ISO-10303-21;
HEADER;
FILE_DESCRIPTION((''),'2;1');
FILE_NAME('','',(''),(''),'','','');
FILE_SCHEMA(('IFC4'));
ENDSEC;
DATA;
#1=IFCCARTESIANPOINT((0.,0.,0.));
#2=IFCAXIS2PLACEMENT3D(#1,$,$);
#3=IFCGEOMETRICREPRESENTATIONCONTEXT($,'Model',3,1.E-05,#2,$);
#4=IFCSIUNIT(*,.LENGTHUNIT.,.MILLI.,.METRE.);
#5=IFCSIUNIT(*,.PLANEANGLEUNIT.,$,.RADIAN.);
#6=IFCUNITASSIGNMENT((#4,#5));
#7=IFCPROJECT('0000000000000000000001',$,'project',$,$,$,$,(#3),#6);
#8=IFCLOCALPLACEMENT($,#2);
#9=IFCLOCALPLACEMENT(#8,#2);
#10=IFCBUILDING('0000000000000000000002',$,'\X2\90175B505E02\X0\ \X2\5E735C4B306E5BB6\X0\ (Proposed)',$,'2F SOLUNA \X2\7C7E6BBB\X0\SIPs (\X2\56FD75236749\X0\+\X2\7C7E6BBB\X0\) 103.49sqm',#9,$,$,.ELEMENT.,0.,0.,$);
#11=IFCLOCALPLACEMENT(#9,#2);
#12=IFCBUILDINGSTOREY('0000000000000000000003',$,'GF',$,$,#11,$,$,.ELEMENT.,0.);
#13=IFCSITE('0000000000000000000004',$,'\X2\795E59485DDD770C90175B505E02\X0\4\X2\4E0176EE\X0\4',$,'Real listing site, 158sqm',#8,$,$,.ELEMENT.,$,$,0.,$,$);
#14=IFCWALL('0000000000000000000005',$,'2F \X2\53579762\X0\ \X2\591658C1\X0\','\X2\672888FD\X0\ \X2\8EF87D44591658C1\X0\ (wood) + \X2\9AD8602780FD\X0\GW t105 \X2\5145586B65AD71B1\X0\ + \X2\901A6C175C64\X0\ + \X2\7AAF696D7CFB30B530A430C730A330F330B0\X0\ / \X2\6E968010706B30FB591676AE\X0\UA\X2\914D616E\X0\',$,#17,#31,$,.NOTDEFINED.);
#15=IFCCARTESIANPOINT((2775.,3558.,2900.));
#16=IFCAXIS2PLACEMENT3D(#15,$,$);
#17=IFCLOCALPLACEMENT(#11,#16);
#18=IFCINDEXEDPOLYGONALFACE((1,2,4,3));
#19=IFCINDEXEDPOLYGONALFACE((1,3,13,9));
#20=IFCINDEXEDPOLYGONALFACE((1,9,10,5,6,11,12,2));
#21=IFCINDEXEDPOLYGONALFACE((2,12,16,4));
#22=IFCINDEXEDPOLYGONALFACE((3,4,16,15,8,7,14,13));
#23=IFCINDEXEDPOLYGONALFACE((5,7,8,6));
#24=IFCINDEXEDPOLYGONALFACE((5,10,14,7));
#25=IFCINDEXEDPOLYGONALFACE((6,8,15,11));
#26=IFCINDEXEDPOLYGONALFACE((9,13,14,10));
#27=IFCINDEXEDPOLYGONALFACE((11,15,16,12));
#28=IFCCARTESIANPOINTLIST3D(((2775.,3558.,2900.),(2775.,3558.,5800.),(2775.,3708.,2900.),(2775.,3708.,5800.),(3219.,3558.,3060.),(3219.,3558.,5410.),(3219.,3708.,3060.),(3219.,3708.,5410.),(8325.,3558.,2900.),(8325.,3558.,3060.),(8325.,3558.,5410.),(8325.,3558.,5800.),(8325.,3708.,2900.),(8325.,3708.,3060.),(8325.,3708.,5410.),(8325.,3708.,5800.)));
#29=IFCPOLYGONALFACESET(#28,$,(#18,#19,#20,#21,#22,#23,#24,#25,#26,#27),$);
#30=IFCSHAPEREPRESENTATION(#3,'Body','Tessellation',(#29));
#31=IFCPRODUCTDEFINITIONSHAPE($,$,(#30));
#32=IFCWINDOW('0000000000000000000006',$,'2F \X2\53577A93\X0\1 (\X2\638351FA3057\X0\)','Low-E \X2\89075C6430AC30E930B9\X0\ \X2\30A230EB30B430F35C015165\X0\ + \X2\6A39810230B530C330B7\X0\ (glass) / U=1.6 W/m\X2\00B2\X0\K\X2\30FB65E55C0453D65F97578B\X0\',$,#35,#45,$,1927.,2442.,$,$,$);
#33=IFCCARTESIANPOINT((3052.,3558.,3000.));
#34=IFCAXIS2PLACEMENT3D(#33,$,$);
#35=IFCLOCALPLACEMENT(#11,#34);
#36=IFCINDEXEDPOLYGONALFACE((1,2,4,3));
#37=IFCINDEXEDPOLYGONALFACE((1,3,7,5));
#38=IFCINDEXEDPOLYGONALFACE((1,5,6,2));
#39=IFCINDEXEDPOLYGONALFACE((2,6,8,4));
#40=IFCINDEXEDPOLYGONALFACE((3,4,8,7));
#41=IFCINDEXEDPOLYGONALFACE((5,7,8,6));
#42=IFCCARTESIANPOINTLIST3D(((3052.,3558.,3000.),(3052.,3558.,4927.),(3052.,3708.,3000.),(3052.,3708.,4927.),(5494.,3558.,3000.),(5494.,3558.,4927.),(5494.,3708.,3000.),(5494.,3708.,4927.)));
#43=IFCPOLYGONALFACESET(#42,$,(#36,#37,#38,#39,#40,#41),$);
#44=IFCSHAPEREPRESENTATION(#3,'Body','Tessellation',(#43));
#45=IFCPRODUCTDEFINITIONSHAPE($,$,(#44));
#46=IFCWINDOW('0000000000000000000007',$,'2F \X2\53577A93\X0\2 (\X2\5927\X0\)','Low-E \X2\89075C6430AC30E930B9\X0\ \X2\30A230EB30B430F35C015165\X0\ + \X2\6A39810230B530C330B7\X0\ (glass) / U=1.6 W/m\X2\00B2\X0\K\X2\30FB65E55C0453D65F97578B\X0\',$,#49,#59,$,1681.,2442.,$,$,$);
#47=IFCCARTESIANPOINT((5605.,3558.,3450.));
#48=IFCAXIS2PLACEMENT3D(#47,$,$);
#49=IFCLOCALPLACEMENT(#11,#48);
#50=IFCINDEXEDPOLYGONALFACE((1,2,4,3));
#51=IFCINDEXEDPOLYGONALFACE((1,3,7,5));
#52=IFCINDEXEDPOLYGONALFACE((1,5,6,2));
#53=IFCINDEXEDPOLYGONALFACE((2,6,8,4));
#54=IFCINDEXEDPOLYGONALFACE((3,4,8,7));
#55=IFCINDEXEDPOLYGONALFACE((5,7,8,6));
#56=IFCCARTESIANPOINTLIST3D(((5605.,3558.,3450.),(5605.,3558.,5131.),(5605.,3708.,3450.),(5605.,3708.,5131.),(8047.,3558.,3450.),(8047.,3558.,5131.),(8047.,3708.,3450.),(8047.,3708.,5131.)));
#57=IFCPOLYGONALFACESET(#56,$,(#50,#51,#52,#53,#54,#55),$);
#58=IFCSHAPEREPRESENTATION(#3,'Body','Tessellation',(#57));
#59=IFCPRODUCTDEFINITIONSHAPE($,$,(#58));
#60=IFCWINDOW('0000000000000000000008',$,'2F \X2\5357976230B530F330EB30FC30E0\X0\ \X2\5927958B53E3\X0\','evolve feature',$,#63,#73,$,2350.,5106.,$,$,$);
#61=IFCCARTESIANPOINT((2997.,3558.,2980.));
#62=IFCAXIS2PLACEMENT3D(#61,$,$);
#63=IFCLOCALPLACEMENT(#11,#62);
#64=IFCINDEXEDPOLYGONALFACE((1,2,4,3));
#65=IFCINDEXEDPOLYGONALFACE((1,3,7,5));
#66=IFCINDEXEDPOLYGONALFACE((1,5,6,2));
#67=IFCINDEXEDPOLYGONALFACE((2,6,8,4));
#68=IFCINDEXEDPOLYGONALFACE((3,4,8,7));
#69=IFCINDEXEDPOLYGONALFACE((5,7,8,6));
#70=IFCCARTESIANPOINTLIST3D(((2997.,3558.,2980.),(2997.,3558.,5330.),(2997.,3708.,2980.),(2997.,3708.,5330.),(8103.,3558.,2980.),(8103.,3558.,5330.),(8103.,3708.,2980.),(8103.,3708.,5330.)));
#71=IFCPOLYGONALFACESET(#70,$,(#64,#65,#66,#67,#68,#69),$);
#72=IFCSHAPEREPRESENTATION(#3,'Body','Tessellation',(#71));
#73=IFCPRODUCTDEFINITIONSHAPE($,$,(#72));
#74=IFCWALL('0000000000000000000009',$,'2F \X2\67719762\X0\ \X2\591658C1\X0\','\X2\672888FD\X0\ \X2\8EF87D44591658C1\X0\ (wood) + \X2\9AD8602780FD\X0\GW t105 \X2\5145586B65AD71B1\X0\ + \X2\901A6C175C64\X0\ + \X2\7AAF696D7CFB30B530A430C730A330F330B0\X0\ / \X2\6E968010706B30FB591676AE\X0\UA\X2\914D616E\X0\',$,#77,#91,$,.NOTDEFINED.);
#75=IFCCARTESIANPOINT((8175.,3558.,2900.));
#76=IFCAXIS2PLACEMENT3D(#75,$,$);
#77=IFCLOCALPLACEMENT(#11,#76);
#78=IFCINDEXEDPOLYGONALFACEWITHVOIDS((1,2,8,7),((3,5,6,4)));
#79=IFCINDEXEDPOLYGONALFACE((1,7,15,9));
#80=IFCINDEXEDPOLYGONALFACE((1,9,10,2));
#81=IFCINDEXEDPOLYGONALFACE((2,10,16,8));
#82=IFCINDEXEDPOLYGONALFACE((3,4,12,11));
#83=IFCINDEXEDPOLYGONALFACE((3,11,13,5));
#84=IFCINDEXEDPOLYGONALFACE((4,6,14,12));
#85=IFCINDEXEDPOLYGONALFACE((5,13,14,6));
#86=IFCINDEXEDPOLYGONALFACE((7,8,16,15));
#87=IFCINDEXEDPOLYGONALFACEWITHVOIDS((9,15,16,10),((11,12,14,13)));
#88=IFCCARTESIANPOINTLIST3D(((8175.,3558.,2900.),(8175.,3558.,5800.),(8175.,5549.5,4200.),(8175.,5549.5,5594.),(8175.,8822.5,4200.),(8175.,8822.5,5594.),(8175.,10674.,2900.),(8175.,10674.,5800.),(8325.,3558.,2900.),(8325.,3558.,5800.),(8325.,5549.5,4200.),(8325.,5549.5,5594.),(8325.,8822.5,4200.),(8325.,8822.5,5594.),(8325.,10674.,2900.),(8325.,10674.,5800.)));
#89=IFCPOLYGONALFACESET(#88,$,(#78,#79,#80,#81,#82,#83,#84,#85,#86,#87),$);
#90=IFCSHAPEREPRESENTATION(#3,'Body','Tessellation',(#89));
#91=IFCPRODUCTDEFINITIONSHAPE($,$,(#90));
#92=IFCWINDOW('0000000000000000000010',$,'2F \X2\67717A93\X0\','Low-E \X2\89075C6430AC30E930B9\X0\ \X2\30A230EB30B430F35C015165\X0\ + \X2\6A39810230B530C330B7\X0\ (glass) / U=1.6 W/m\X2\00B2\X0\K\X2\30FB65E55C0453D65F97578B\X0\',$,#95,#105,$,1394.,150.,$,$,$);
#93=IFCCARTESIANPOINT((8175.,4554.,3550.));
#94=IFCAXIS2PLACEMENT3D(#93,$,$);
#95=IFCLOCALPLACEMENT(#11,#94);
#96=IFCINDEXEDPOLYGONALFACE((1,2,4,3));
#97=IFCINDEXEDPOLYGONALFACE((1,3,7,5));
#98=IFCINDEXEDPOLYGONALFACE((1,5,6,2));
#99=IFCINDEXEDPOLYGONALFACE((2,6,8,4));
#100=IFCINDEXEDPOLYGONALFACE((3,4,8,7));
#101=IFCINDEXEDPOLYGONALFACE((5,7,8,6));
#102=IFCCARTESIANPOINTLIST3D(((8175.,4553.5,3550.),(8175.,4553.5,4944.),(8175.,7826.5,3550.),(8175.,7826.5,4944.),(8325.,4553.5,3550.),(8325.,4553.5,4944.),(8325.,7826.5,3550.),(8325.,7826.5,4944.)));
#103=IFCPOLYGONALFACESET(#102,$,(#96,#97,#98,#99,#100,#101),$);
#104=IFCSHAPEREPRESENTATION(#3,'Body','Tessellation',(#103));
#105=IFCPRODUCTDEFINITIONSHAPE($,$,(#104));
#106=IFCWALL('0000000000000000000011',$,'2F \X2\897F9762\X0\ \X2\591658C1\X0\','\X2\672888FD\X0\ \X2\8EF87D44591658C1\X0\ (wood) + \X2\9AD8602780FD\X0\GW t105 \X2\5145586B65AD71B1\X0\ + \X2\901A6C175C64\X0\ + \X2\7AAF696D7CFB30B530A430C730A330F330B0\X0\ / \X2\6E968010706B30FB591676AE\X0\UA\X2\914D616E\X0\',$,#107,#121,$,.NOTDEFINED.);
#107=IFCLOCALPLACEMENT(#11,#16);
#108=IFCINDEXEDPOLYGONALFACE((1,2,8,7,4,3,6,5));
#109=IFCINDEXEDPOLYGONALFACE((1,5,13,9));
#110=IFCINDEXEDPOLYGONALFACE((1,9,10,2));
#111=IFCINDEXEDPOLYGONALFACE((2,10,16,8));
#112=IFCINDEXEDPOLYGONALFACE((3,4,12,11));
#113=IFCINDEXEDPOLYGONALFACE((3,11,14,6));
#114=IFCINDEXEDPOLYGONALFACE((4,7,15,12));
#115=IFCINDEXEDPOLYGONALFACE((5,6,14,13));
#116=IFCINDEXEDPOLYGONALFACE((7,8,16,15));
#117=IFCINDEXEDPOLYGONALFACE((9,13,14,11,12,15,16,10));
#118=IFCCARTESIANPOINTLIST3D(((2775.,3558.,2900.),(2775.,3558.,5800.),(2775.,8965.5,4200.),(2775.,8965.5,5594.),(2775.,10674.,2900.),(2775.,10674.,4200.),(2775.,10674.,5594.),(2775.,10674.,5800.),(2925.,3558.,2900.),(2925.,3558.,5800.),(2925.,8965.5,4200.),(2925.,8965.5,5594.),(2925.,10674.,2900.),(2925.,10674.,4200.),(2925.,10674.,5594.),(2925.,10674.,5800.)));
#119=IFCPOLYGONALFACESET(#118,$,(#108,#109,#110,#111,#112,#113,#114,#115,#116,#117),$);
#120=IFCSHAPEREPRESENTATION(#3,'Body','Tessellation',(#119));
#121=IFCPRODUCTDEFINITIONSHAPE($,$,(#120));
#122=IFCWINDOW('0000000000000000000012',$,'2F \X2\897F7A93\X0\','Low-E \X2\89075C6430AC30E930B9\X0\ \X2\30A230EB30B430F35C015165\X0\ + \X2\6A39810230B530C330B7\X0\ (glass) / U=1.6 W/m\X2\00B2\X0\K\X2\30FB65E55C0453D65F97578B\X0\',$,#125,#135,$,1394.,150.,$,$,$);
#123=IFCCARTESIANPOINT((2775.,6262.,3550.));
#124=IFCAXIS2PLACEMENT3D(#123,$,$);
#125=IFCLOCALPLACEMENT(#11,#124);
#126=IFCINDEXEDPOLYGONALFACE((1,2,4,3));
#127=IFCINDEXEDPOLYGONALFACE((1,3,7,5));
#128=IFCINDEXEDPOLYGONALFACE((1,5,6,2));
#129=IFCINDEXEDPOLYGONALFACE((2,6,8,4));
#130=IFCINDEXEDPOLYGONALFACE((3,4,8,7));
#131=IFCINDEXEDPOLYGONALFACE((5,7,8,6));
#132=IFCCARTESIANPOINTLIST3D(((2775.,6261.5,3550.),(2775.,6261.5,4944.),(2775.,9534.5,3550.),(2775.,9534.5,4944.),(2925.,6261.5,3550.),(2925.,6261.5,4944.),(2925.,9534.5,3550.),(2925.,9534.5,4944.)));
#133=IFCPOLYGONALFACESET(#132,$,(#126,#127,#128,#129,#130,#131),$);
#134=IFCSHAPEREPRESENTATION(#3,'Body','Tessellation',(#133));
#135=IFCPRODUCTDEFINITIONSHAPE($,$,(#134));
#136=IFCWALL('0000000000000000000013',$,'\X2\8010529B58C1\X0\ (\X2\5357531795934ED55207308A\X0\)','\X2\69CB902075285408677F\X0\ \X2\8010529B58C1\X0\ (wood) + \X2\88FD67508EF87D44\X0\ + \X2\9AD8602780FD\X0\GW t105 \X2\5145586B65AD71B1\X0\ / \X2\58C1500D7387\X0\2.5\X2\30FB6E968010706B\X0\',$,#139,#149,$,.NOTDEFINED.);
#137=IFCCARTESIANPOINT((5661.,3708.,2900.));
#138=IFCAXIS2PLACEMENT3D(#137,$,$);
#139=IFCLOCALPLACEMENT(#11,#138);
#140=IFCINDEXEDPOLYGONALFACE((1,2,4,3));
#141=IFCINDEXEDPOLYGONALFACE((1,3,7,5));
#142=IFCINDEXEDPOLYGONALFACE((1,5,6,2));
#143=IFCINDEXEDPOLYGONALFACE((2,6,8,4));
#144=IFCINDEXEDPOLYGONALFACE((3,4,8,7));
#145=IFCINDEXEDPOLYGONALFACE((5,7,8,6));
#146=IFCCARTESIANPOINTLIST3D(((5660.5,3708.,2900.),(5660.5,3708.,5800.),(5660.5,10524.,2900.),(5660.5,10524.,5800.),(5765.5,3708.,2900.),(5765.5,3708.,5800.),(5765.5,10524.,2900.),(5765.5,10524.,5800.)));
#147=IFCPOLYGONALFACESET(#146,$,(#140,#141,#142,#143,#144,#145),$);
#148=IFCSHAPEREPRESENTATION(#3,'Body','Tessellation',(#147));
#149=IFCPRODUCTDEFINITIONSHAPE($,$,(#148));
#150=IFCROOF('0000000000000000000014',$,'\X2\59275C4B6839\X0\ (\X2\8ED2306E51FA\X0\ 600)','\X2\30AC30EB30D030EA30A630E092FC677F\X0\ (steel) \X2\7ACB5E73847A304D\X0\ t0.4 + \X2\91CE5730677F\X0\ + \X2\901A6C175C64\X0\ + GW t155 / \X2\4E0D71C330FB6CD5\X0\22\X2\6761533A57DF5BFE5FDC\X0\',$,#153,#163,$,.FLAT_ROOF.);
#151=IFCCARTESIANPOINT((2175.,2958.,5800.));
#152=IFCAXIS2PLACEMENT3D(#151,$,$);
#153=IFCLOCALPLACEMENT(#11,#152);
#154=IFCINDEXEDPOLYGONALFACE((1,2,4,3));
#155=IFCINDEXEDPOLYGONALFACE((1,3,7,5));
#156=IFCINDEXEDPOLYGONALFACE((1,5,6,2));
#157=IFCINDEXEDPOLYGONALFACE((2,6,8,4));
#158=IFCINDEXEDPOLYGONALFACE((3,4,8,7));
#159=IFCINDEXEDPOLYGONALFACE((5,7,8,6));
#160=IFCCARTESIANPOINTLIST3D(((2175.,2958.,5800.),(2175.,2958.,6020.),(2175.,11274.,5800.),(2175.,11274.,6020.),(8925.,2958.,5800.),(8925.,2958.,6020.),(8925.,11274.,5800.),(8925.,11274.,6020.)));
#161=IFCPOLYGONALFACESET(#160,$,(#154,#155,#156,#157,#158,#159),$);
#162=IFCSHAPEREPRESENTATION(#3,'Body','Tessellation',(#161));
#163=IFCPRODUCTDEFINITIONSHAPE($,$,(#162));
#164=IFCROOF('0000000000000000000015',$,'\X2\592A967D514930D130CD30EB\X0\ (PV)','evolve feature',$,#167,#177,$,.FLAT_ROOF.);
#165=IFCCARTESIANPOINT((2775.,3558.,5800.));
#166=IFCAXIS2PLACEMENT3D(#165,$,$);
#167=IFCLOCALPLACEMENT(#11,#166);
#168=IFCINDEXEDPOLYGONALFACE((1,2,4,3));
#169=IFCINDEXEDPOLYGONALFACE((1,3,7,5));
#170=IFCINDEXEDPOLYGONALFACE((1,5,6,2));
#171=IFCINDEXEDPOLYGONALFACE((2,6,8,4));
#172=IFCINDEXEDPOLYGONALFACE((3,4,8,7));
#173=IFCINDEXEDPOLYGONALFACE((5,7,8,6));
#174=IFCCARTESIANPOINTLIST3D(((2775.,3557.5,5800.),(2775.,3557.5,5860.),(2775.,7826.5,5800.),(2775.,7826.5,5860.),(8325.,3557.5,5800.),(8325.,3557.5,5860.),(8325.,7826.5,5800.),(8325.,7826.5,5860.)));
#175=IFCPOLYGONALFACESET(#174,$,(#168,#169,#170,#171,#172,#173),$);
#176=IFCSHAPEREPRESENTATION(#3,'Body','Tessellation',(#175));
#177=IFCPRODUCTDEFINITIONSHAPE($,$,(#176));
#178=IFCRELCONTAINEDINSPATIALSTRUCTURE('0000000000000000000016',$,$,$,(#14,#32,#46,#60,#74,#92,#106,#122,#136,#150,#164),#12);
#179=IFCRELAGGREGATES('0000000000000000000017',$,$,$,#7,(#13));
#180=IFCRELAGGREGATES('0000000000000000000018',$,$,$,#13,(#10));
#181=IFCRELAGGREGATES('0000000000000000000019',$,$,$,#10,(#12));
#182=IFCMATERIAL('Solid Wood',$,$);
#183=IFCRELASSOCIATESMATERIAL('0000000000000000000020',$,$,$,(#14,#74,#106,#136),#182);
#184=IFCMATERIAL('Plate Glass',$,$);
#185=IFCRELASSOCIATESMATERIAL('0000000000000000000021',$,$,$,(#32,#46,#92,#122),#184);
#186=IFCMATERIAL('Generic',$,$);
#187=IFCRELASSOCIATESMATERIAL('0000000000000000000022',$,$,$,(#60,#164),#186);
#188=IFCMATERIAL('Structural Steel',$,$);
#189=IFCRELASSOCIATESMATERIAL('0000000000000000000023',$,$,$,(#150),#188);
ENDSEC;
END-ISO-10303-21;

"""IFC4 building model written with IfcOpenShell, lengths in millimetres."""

from ifc_helpers import new_model, si_unit, frame, frame_2d, origin, place, context, project, spatial, rectangle, extrude, material, element, fill, save


model = new_model("IFC4")

# Units and contexts
model_context = context("Model", 3, precision=1e-05, world=origin())
ifc_project = project(units=[si_unit("LENGTHUNIT", "METRE", prefix="MILLI"), si_unit("PLANEANGLEUNIT", "RADIAN")], contexts=[model_context])

# Site, building, storey
site_placement = place(None, origin())
site = spatial("IfcSite", under=ifc_project, at=site_placement, Name="神奈川県逗子市4丁目4", ObjectType="Real listing site, 158sqm", CompositionType="ELEMENT", RefElevation=0.0)
building_placement = place(site_placement, origin())
building = spatial("IfcBuilding", under=site, at=building_placement, Name="逗子市 平屋の家 (Proposed)", ObjectType="2F SOLUNA 籾殻SIPs (国産杉+籾殻) 103.49sqm", CompositionType="ELEMENT", ElevationOfRefHeight=0.0, ElevationOfTerrain=0.0)
storey_placement = place(building_placement, origin())
storey = spatial("IfcBuildingStorey", under=building, at=storey_placement, Name="GF", CompositionType="ELEMENT", Elevation=0.0)

# Shared definitions
ifc_material_1 = material(Name="Solid Wood")

# Wall, openings, windows
wall_1_placement = place(storey_placement, frame((2775.0, 3558.0, 2900.0)))
wall_1 = element("IfcWall", 1, at=wall_1_placement, inside=storey, material=ifc_material_1, Name="2F 南面 外壁", Description="木製 軸組外壁 (wood) + 高性能GW t105 充填断熱 + 通気層 + 窯業系サイディング / 準耐火・外皮UA配慮", PredefinedType="NOTDEFINED", context=model_context, shape_type="SweptSolid", body=[
    extrude(rectangle(XDim=5550.0, YDim=150.0, at=frame_2d((2775.0, 75.0))), frame((2775.0, 3558.0, 2900.0)), (0.0, 0.0, 1.0), 2900.0),
])
opening_1_placement = place(storey_placement, frame((3052.0, 3558.0, 3000.0)))
opening_1 = element("IfcOpeningElement", 2, at=opening_1_placement, cuts=wall_1, PredefinedType="NOTDEFINED", context=model_context, shape_type="SweptSolid", body=[
    extrude(rectangle(XDim=2442.0, YDim=150.0, at=frame_2d((1221.0, 75.0))), frame((3052.0, 3558.0, 3000.0)), (0.0, 0.0, 1.0), 1927.0),
])
opening_2_placement = place(storey_placement, frame((5605.0, 3558.0, 3450.0)))
opening_2 = element("IfcOpeningElement", 3, at=opening_2_placement, cuts=wall_1, PredefinedType="NOTDEFINED", context=model_context, shape_type="SweptSolid", body=[
    extrude(rectangle(XDim=2442.0, YDim=150.0, at=frame_2d((1221.0, 75.0))), frame((5605.0, 3558.0, 3450.0)), (0.0, 0.0, 1.0), 1681.0),
])
opening_3_placement = place(storey_placement, frame((2997.0, 3558.0, 2980.0)))
opening_3 = element("IfcOpeningElement", 4, at=opening_3_placement, cuts=wall_1, PredefinedType="NOTDEFINED", context=model_context, shape_type="SweptSolid", body=[
    extrude(rectangle(XDim=5106.0, YDim=150.0, at=frame_2d((2553.0, 75.0))), frame((2997.0, 3558.0, 2980.0)), (0.0, 0.0, 1.0), 2350.0),
])
ifc_material_2 = material(Name="Plate Glass")
window_1_placement = place(storey_placement, frame((3052.0, 3558.0, 3000.0)))
window_1 = element("IfcWindow", 5, at=window_1_placement, inside=storey, material=ifc_material_2, Name="2F 南窓1 (掃出し)", Description="Low-E 複層ガラス アルゴン封入 + 樹脂サッシ (glass) / U=1.6 W/m²K・日射取得型", OverallHeight=1927.0, OverallWidth=2442.0, context=model_context, shape_type="SweptSolid", body=[
    extrude(rectangle(XDim=2442.0, YDim=150.0, at=frame_2d((1221.0, 75.0))), frame((3052.0, 3558.0, 3000.0)), (0.0, 0.0, 1.0), 1927.0),
])
fill(opening_1, window_1)
window_2_placement = place(storey_placement, frame((5605.0, 3558.0, 3450.0)))
window_2 = element("IfcWindow", 6, at=window_2_placement, inside=storey, material=ifc_material_2, Name="2F 南窓2 (大)", Description="Low-E 複層ガラス アルゴン封入 + 樹脂サッシ (glass) / U=1.6 W/m²K・日射取得型", OverallHeight=1681.0, OverallWidth=2442.0, context=model_context, shape_type="SweptSolid", body=[
    extrude(rectangle(XDim=2442.0, YDim=150.0, at=frame_2d((1221.0, 75.0))), frame((5605.0, 3558.0, 3450.0)), (0.0, 0.0, 1.0), 1681.0),
])
fill(opening_2, window_2)
ifc_material_3 = material(Name="Generic")
window_3_placement = place(storey_placement, frame((2997.0, 3558.0, 2980.0)))
window_3 = element("IfcWindow", 7, at=window_3_placement, inside=storey, material=ifc_material_3, Name="2F 南面サンルーム 大開口", Description="evolve feature", OverallHeight=2350.0, OverallWidth=5106.0, context=model_context, shape_type="SweptSolid", body=[
    extrude(rectangle(XDim=5106.0, YDim=150.0, at=frame_2d((2553.0, 75.0))), frame((2997.0, 3558.0, 2980.0)), (0.0, 0.0, 1.0), 2350.0),
])
fill(opening_3, window_3)

# Walls, openings, windows
wall_2_placement = place(storey_placement, frame((8175.0, 3558.0, 2900.0)))
wall_2 = element("IfcWall", 8, at=wall_2_placement, inside=storey, material=ifc_material_1, Name="2F 東面 外壁", Description="木製 軸組外壁 (wood) + 高性能GW t105 充填断熱 + 通気層 + 窯業系サイディング / 準耐火・外皮UA配慮", PredefinedType="NOTDEFINED", context=model_context, shape_type="SweptSolid", body=[
    extrude(rectangle(XDim=150.0, YDim=7116.0, at=frame_2d((75.0, 3558.0))), frame((8175.0, 3558.0, 2900.0)), (0.0, 0.0, 1.0), 2900.0),
])
opening_4_placement = place(storey_placement, frame((8175.0, 4554.0, 3550.0)))
opening_4 = element("IfcOpeningElement", 9, at=opening_4_placement, cuts=wall_2, PredefinedType="NOTDEFINED", context=model_context, shape_type="SweptSolid", body=[
    extrude(rectangle(XDim=150.0, YDim=3273.0, at=frame_2d((75.0, 1636.0))), frame((8175.0, 4554.0, 3550.0)), (0.0, 0.0, 1.0), 1394.0),
])
window_4_placement = place(storey_placement, frame((8175.0, 4554.0, 3550.0)))
window_4 = element("IfcWindow", 10, at=window_4_placement, inside=storey, material=ifc_material_2, Name="2F 東窓", Description="Low-E 複層ガラス アルゴン封入 + 樹脂サッシ (glass) / U=1.6 W/m²K・日射取得型", OverallHeight=1394.0, OverallWidth=150.0, context=model_context, shape_type="SweptSolid", body=[
    extrude(rectangle(XDim=150.0, YDim=3273.0, at=frame_2d((75.0, 1636.0))), frame((8175.0, 4554.0, 3550.0)), (0.0, 0.0, 1.0), 1394.0),
])
fill(opening_4, window_4)
wall_3_placement = place(storey_placement, frame((2775.0, 3558.0, 2900.0)))
wall_3 = element("IfcWall", 11, at=wall_3_placement, inside=storey, material=ifc_material_1, Name="2F 西面 外壁", Description="木製 軸組外壁 (wood) + 高性能GW t105 充填断熱 + 通気層 + 窯業系サイディング / 準耐火・外皮UA配慮", PredefinedType="NOTDEFINED", context=model_context, shape_type="SweptSolid", body=[
    extrude(rectangle(XDim=150.0, YDim=7116.0, at=frame_2d((75.0, 3558.0))), frame((2775.0, 3558.0, 2900.0)), (0.0, 0.0, 1.0), 2900.0),
])
opening_5_placement = place(storey_placement, frame((2775.0, 6262.0, 3550.0)))
opening_5 = element("IfcOpeningElement", 12, at=opening_5_placement, cuts=wall_3, PredefinedType="NOTDEFINED", context=model_context, shape_type="SweptSolid", body=[
    extrude(rectangle(XDim=150.0, YDim=3273.0, at=frame_2d((75.0, 1636.0))), frame((2775.0, 6262.0, 3550.0)), (0.0, 0.0, 1.0), 1394.0),
])
window_5_placement = place(storey_placement, frame((2775.0, 6262.0, 3550.0)))
window_5 = element("IfcWindow", 13, at=window_5_placement, inside=storey, material=ifc_material_2, Name="2F 西窓", Description="Low-E 複層ガラス アルゴン封入 + 樹脂サッシ (glass) / U=1.6 W/m²K・日射取得型", OverallHeight=1394.0, OverallWidth=150.0, context=model_context, shape_type="SweptSolid", body=[
    extrude(rectangle(XDim=150.0, YDim=3273.0, at=frame_2d((75.0, 1636.0))), frame((2775.0, 6262.0, 3550.0)), (0.0, 0.0, 1.0), 1394.0),
])
fill(opening_5, window_5)

# Wall
wall_4_placement = place(storey_placement, frame((5661.0, 3708.0, 2900.0)))
element("IfcWall", 14, at=wall_4_placement, inside=storey, material=ifc_material_1, Name="耐力壁 (南北間仕切り)", Description="構造用合板 耐力壁 (wood) + 製材軸組 + 高性能GW t105 充填断熱 / 壁倍率2.5・準耐火", PredefinedType="NOTDEFINED", context=model_context, shape_type="SweptSolid", body=[
    extrude(rectangle(XDim=105.0, YDim=6816.0, at=frame_2d((52.0, 3408.0))), frame((5661.0, 3708.0, 2900.0)), (0.0, 0.0, 1.0), 2900.0),
])

# Roofs
ifc_material_4 = material(Name="Structural Steel")
roof_1_placement = place(storey_placement, frame((2175.0, 2958.0, 5800.0)))
element("IfcRoof", 15, at=roof_1_placement, inside=storey, material=ifc_material_4, Name="大屋根 (軒の出 600)", Description="ガルバリウム鋼板 (steel) 立平葺き t0.4 + 野地板 + 通気層 + GW t155 / 不燃・法22条区域対応", PredefinedType="FLAT_ROOF", context=model_context, shape_type="SweptSolid", body=[
    extrude(rectangle(XDim=6750.0, YDim=8316.0, at=frame_2d((3375.0, 4158.0))), frame((2175.0, 2958.0, 5800.0)), (0.0, 0.0, 1.0), 220.0),
])
roof_2_placement = place(storey_placement, frame((2775.0, 3558.0, 5800.0)))
element("IfcRoof", 16, at=roof_2_placement, inside=storey, material=ifc_material_3, Name="太陽光パネル (PV)", Description="evolve feature", PredefinedType="FLAT_ROOF", context=model_context, shape_type="SweptSolid", body=[
    extrude(rectangle(XDim=5550.0, YDim=4269.0, at=frame_2d((2775.0, 2134.0))), frame((2775.0, 3558.0, 5800.0)), (0.0, 0.0, 1.0), 60.0),
])

save(model, "model.ifc")
